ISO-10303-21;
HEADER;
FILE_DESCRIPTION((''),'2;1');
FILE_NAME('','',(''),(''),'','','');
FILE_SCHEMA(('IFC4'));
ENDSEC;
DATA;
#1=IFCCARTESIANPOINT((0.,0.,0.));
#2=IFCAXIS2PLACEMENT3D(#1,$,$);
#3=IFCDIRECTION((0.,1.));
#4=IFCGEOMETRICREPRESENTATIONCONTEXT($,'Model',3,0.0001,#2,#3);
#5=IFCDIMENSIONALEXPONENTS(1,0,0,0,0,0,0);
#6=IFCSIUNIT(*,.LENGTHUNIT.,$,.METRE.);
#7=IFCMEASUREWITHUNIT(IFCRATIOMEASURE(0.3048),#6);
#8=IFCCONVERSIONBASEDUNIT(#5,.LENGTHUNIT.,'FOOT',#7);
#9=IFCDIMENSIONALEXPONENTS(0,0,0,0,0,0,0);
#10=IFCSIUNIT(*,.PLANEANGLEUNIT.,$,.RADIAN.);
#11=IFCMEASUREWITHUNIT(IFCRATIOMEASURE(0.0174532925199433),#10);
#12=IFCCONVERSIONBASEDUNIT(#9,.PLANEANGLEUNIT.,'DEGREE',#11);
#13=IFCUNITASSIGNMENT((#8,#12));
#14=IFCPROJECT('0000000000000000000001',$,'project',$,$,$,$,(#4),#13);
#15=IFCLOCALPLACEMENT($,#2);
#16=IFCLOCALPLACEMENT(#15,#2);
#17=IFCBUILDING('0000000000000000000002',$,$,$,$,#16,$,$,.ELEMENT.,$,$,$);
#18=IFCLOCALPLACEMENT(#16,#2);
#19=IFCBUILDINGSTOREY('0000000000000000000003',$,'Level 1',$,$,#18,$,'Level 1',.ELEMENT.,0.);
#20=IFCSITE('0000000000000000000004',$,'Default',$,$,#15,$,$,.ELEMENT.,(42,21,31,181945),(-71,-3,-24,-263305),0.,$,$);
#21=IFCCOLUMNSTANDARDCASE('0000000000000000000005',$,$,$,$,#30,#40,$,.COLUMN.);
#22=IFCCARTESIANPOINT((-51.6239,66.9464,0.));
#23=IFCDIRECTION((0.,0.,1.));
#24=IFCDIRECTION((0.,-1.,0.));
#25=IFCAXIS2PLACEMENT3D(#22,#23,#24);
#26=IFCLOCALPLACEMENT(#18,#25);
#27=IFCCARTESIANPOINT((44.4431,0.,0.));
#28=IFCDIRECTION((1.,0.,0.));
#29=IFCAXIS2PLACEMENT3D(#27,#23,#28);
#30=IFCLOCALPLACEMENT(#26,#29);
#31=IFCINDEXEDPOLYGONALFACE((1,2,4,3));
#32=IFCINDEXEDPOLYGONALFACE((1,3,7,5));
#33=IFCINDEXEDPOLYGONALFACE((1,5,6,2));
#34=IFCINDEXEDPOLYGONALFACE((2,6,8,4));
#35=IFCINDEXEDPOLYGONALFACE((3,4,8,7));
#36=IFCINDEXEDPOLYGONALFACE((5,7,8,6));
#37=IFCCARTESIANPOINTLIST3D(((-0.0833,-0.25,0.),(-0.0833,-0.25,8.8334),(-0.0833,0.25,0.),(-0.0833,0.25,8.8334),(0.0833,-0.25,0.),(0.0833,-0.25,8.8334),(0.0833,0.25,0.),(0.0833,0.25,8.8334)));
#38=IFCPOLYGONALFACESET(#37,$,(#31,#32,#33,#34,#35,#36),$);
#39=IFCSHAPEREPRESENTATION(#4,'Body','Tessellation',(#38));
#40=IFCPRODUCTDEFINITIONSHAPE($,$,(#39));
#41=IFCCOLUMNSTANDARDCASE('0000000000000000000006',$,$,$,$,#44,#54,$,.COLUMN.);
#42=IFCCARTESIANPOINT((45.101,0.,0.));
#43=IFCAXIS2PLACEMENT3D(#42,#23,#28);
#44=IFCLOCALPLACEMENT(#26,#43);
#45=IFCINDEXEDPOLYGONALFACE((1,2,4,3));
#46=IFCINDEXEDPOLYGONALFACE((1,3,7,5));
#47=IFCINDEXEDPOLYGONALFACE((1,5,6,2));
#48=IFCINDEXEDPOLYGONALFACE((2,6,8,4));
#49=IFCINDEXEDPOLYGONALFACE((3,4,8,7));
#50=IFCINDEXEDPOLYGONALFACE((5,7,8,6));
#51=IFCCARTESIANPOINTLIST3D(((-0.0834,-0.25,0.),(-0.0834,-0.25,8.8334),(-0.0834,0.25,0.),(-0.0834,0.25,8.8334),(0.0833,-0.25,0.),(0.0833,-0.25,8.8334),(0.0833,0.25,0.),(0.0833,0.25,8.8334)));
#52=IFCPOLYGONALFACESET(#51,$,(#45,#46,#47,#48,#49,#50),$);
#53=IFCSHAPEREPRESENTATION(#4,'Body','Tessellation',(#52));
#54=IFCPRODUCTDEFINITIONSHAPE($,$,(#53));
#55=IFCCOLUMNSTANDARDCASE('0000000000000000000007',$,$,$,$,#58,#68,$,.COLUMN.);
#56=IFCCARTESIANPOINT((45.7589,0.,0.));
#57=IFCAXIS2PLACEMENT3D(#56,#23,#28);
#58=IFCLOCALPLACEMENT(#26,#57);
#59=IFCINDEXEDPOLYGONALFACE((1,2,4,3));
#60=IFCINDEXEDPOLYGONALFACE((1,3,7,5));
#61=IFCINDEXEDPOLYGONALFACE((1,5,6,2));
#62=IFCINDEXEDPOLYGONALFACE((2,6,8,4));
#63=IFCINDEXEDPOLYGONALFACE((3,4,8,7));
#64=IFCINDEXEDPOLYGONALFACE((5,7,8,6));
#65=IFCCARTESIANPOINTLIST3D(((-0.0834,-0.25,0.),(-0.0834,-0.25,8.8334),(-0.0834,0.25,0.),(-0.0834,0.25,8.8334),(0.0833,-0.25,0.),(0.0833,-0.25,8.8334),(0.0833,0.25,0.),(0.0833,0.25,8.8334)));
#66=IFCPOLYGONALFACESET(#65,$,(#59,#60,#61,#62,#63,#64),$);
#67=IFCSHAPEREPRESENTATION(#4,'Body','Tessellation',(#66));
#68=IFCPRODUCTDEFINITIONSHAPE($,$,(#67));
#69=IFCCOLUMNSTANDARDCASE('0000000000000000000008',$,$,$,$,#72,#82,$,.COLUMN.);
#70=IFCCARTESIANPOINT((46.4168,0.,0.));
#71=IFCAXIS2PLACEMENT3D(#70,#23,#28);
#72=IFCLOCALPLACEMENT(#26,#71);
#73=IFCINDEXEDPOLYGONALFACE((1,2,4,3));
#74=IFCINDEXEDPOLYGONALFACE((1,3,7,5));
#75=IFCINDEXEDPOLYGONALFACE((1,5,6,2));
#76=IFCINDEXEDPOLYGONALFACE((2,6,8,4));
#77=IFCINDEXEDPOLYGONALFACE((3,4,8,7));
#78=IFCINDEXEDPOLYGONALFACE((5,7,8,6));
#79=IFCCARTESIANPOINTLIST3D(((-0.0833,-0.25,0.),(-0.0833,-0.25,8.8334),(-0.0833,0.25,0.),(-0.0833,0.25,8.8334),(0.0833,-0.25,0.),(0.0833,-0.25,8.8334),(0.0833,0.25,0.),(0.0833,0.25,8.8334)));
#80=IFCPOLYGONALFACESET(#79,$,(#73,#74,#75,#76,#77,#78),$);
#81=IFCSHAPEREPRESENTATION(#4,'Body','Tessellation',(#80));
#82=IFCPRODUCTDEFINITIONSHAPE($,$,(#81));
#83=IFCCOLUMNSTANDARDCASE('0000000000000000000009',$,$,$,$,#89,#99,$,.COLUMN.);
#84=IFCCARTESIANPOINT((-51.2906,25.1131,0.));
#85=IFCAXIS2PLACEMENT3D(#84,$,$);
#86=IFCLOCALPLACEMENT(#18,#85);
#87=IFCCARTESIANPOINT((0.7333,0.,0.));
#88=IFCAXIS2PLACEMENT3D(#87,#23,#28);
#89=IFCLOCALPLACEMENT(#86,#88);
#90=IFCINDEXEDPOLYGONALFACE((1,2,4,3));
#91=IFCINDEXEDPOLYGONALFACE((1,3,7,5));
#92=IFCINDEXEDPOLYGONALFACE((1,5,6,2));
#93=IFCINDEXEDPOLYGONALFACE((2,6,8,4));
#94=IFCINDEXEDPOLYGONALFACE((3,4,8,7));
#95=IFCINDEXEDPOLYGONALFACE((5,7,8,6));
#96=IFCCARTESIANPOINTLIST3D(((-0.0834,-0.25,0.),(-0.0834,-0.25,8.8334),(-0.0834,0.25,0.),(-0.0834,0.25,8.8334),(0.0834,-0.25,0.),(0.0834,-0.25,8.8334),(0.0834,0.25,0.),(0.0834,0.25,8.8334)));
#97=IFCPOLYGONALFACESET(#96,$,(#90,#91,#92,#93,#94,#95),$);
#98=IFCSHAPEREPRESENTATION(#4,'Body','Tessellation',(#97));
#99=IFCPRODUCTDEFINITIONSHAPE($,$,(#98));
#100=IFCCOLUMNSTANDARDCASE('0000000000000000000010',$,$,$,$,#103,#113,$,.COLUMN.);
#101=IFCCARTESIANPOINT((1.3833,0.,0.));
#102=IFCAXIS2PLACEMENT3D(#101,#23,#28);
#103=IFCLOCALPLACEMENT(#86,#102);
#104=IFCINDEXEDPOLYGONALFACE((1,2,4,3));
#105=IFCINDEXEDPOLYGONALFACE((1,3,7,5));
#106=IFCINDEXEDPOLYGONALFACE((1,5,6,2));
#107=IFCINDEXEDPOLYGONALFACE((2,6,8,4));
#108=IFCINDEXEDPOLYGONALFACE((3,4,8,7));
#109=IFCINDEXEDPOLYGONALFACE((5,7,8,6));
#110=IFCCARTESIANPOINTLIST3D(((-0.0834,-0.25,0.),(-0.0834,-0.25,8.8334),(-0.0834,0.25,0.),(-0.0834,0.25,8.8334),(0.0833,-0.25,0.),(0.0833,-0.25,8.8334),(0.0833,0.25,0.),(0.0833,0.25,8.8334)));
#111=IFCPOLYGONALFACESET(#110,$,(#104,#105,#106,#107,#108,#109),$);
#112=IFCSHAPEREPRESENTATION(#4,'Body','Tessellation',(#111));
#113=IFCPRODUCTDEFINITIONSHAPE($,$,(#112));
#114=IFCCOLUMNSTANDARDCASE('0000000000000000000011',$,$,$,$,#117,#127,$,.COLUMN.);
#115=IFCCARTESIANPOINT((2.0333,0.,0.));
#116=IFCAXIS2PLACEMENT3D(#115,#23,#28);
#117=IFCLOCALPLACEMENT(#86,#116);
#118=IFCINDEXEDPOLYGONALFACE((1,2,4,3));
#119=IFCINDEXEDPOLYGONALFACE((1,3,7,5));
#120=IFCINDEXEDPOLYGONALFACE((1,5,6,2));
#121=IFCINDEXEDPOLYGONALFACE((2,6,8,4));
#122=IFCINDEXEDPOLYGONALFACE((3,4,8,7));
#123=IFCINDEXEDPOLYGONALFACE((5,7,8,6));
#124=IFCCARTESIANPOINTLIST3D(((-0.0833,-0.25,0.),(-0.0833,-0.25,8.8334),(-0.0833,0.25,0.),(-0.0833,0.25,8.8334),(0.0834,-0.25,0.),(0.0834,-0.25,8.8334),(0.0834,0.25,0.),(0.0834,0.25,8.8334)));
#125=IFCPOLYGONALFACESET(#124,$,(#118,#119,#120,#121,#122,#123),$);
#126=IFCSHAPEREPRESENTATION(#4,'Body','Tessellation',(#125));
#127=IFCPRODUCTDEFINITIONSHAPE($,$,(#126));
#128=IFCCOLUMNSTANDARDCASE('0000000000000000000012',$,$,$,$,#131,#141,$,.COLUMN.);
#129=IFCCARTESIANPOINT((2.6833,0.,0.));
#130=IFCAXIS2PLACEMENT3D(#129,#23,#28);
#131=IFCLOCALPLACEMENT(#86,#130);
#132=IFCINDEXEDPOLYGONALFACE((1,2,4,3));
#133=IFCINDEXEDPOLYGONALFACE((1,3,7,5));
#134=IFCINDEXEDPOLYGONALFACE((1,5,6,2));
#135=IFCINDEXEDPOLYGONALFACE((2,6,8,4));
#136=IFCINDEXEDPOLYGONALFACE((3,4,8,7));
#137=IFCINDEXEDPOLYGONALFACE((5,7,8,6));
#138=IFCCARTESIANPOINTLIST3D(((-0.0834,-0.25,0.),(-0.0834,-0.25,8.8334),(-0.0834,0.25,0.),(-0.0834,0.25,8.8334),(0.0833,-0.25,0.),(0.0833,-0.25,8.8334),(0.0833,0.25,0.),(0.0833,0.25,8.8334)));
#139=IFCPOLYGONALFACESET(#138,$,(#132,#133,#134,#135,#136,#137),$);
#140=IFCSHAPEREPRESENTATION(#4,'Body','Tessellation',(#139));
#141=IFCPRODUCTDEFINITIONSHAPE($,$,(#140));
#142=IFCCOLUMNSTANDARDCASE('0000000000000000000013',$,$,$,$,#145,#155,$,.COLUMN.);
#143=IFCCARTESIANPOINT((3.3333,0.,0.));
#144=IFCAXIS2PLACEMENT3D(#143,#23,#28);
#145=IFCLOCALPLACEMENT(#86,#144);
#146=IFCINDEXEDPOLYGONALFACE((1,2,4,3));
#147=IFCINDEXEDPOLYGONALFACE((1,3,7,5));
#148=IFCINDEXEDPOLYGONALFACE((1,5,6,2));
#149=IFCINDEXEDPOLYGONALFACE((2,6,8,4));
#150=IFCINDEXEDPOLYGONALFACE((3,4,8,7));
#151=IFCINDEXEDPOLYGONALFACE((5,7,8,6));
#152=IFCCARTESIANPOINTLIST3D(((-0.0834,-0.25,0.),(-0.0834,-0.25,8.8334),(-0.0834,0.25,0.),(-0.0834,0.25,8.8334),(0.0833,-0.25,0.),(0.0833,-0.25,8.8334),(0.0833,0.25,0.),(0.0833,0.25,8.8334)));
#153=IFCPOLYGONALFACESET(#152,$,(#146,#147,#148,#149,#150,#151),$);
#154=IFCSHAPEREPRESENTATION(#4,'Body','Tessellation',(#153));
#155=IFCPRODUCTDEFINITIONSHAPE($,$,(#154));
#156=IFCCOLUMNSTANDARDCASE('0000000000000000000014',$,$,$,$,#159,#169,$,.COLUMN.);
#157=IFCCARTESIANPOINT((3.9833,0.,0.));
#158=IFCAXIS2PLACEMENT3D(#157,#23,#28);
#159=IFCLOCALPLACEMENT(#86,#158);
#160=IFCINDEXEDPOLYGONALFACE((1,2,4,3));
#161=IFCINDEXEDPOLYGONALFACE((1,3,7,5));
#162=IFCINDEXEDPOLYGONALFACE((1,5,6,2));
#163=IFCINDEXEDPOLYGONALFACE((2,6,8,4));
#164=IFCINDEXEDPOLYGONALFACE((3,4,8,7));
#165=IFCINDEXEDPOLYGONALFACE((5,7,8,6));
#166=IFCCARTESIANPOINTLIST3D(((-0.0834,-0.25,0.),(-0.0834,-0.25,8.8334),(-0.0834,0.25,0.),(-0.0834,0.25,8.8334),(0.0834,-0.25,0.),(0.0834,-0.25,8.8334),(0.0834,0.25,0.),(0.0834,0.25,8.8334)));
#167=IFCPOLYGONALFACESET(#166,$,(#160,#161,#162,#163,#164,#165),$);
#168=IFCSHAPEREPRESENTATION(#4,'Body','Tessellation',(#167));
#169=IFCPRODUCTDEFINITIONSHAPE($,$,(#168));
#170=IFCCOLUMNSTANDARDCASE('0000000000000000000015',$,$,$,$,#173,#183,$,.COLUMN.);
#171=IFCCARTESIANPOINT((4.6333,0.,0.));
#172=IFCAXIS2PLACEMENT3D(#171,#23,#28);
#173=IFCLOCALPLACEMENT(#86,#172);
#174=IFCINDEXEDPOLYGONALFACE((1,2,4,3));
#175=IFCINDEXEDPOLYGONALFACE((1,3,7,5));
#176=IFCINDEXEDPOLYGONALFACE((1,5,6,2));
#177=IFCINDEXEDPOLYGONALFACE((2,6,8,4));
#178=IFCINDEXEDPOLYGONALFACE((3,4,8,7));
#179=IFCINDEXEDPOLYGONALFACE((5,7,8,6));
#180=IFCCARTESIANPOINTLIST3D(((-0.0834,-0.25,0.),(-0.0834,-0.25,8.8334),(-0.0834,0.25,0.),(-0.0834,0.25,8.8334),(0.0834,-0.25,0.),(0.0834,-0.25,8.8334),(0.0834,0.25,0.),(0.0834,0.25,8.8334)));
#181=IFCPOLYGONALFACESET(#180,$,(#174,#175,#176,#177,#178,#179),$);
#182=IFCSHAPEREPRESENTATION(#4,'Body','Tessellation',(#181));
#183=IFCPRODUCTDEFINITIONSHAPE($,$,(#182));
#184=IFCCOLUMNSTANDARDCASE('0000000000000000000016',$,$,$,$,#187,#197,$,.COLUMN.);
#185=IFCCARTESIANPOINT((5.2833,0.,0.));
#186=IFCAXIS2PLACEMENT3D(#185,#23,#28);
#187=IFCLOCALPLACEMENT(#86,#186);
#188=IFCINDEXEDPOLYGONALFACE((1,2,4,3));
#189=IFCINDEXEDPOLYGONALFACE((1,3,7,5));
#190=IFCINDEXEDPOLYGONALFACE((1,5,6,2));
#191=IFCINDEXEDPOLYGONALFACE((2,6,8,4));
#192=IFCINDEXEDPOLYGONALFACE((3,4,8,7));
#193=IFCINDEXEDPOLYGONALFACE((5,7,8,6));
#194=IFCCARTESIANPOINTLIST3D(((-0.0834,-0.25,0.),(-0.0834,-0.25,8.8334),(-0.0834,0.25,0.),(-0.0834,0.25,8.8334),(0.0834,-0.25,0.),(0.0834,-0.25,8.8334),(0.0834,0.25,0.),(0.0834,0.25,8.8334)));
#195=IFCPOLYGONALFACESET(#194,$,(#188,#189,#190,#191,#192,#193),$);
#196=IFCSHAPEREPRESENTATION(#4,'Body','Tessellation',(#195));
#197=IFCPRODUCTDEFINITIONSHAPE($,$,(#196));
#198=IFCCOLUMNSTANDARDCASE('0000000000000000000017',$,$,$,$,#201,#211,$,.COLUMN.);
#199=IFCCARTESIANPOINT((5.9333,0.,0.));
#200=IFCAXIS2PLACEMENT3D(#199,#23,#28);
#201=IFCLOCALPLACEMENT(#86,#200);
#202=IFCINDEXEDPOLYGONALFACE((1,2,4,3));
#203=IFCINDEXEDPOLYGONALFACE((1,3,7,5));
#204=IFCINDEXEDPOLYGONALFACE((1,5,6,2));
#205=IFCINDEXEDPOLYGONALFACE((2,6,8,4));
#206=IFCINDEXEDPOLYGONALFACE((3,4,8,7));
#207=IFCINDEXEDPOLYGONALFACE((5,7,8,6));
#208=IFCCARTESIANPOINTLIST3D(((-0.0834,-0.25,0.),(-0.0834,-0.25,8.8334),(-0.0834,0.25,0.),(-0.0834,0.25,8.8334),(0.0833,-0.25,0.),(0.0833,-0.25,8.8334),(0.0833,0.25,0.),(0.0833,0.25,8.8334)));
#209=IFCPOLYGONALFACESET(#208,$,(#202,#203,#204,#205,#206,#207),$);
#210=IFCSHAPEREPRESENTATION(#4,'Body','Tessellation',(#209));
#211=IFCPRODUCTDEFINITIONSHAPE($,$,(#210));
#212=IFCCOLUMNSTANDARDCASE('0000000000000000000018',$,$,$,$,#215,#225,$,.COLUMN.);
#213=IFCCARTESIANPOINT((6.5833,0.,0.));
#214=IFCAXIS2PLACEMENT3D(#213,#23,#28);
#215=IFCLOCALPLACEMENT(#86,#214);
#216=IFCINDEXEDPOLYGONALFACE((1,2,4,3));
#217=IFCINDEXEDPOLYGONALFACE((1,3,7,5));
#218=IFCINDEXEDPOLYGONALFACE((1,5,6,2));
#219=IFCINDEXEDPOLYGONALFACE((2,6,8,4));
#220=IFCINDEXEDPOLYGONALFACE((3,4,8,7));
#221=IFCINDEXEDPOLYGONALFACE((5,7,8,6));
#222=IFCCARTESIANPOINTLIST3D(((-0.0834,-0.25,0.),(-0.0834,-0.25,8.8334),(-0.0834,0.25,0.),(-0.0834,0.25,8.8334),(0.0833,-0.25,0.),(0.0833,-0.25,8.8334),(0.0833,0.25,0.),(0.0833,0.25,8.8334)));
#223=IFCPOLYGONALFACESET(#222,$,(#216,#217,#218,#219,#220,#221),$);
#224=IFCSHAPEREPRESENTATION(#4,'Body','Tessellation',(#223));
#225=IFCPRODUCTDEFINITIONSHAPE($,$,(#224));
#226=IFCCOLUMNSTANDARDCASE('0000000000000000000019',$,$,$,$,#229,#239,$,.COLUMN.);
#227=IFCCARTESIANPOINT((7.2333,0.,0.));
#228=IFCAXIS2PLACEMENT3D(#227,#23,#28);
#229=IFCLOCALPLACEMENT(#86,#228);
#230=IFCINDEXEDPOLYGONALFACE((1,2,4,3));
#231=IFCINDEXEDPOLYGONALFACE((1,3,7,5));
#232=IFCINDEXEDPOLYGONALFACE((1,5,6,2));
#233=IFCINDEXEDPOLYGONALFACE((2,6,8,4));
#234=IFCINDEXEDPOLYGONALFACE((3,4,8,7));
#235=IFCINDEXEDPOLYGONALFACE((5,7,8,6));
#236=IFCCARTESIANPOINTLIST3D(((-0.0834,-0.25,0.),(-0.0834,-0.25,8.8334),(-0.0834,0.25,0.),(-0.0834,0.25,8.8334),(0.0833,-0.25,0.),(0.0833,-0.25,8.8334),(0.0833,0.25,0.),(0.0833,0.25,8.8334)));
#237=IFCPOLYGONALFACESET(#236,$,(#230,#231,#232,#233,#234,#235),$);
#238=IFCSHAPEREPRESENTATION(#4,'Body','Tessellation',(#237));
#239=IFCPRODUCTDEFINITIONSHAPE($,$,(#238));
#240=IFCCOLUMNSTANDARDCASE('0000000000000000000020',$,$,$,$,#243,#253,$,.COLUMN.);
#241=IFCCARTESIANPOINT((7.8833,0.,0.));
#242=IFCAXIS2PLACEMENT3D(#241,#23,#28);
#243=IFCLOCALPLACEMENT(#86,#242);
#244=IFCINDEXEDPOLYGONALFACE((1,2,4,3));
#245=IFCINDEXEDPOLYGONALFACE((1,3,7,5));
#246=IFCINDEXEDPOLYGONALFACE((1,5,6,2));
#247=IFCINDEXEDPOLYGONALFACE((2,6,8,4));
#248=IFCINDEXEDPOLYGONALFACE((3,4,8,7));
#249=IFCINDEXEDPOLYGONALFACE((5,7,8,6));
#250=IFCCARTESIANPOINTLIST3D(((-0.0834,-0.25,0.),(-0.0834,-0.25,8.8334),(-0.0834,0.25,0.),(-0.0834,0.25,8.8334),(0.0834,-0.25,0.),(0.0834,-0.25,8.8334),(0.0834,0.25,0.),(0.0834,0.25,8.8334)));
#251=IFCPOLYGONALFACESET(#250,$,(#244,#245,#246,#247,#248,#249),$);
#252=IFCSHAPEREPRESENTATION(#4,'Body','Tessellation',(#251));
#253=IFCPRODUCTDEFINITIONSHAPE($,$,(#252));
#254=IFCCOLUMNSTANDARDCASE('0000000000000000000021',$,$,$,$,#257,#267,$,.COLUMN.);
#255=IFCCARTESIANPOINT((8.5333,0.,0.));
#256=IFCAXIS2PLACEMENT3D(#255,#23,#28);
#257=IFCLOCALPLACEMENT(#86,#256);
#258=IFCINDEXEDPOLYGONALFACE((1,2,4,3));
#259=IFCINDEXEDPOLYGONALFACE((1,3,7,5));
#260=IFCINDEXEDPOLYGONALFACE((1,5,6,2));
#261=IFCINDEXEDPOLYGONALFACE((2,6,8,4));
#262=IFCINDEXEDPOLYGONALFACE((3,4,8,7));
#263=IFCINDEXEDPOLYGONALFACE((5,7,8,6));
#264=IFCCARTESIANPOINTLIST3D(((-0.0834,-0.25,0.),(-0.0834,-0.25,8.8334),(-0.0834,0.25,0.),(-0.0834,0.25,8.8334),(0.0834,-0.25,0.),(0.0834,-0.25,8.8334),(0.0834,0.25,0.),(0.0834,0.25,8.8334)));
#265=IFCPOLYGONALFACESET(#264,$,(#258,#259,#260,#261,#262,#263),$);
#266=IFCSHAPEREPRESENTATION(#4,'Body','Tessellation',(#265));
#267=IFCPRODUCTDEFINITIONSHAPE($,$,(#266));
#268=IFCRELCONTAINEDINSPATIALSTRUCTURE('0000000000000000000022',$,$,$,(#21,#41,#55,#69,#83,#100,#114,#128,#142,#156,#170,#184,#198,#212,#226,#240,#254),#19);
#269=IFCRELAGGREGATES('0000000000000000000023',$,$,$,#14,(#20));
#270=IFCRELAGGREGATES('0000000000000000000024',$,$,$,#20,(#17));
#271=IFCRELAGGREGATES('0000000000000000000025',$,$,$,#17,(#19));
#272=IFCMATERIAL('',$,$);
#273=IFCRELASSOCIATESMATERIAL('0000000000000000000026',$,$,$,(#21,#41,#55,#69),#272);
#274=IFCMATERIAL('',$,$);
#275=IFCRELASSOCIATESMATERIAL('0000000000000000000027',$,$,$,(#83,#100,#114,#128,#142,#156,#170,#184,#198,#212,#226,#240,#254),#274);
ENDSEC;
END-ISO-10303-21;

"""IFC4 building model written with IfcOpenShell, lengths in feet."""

from ifc_helpers import new_model, entity, si_unit, converted_unit, direction, frame, origin, place, context, project, spatial, rectangle, extrude, material, element, save


model = new_model("IFC4")

# Units and contexts
model_context = context("Model", 3, precision=0.0001, world=origin(), true_north=direction((0.0, 1.0)))
ifc_project = project(units=[converted_unit("LENGTHUNIT", "FOOT", entity("IfcRatioMeasure", 0.3048), si_unit("LENGTHUNIT", "METRE"), dimensions=[1, 0, 0, 0, 0, 0, 0]), converted_unit("PLANEANGLEUNIT", "DEGREE", entity("IfcRatioMeasure", 0.0174532925199433), si_unit("PLANEANGLEUNIT", "RADIAN"), dimensions=[0, 0, 0, 0, 0, 0, 0])], contexts=[model_context])

# Site, building, storey
site_placement = place(None, origin())
site = spatial("IfcSite", under=ifc_project, at=site_placement, Name="Default", CompositionType="ELEMENT", RefLatitude=(42, 21, 31, 181945), RefLongitude=(-71, -3, -24, -263305), RefElevation=0.0)
building_placement = place(site_placement, origin())
building = spatial("IfcBuilding", under=site, at=building_placement, CompositionType="ELEMENT")
storey_placement = place(building_placement, origin())
storey = spatial("IfcBuildingStorey", under=building, at=storey_placement, Name="Level 1", LongName="Level 1", CompositionType="ELEMENT", Elevation=0.0)

# Columns
ifc_material_1 = material(Name="")
placement_1 = place(storey_placement, frame((-51.6239, 66.9464, 0.0), z_axis=(0.0, 0.0, 1.0), x_axis=(0.0, -1.0, 0.0)))
for number, where, z_axis, x_axis in (
    (1, (44.4431, 0.0, 0.0), (0.0, 0.0, 1.0), (1.0, 0.0, 0.0)),
    (2, (45.101, 0.0, 0.0), (0.0, 0.0, 1.0), (1.0, 0.0, 0.0)),
    (3, (45.7589, 0.0, 0.0), (0.0, 0.0, 1.0), (1.0, 0.0, 0.0)),
    (4, (46.4168, 0.0, 0.0), (0.0, 0.0, 1.0), (1.0, 0.0, 0.0)),
):
    element("IfcColumnStandardCase", number, at=place(placement_1, frame(where, z_axis=z_axis, x_axis=x_axis)), inside=storey, material=ifc_material_1, PredefinedType="COLUMN", context=model_context, shape_type="SweptSolid", body=[
        extrude(rectangle(XDim=0.1667, YDim=0.5), origin(), (0.0, 0.0, 1.0), 8.8334),
    ])
ifc_material_2 = material(Name="")
placement_2 = place(storey_placement, frame((-51.2906, 25.1131, 0.0)))
for number, where, z_axis, x_axis in (
    (5, (0.7333, 0.0, 0.0), (0.0, 0.0, 1.0), (1.0, 0.0, 0.0)),
    (6, (1.3833, 0.0, 0.0), (0.0, 0.0, 1.0), (1.0, 0.0, 0.0)),
    (7, (2.0333, 0.0, 0.0), (0.0, 0.0, 1.0), (1.0, 0.0, 0.0)),
    (8, (2.6833, 0.0, 0.0), (0.0, 0.0, 1.0), (1.0, 0.0, 0.0)),
    (9, (3.3333, 0.0, 0.0), (0.0, 0.0, 1.0), (1.0, 0.0, 0.0)),
    (10, (3.9833, 0.0, 0.0), (0.0, 0.0, 1.0), (1.0, 0.0, 0.0)),
    (11, (4.6333, 0.0, 0.0), (0.0, 0.0, 1.0), (1.0, 0.0, 0.0)),
    (12, (5.2833, 0.0, 0.0), (0.0, 0.0, 1.0), (1.0, 0.0, 0.0)),
    (13, (5.9333, 0.0, 0.0), (0.0, 0.0, 1.0), (1.0, 0.0, 0.0)),
    (14, (6.5833, 0.0, 0.0), (0.0, 0.0, 1.0), (1.0, 0.0, 0.0)),
    (15, (7.2333, 0.0, 0.0), (0.0, 0.0, 1.0), (1.0, 0.0, 0.0)),
    (16, (7.8833, 0.0, 0.0), (0.0, 0.0, 1.0), (1.0, 0.0, 0.0)),
    (17, (8.5333, 0.0, 0.0), (0.0, 0.0, 1.0), (1.0, 0.0, 0.0)),
):
    element("IfcColumnStandardCase", number, at=place(placement_2, frame(where, z_axis=z_axis, x_axis=x_axis)), inside=storey, material=ifc_material_2, PredefinedType="COLUMN", context=model_context, shape_type="SweptSolid", body=[
        extrude(rectangle(XDim=0.1667, YDim=0.5), origin(), (0.0, 0.0, 1.0), 8.8334),
    ])

save(model, "model.ifc")
